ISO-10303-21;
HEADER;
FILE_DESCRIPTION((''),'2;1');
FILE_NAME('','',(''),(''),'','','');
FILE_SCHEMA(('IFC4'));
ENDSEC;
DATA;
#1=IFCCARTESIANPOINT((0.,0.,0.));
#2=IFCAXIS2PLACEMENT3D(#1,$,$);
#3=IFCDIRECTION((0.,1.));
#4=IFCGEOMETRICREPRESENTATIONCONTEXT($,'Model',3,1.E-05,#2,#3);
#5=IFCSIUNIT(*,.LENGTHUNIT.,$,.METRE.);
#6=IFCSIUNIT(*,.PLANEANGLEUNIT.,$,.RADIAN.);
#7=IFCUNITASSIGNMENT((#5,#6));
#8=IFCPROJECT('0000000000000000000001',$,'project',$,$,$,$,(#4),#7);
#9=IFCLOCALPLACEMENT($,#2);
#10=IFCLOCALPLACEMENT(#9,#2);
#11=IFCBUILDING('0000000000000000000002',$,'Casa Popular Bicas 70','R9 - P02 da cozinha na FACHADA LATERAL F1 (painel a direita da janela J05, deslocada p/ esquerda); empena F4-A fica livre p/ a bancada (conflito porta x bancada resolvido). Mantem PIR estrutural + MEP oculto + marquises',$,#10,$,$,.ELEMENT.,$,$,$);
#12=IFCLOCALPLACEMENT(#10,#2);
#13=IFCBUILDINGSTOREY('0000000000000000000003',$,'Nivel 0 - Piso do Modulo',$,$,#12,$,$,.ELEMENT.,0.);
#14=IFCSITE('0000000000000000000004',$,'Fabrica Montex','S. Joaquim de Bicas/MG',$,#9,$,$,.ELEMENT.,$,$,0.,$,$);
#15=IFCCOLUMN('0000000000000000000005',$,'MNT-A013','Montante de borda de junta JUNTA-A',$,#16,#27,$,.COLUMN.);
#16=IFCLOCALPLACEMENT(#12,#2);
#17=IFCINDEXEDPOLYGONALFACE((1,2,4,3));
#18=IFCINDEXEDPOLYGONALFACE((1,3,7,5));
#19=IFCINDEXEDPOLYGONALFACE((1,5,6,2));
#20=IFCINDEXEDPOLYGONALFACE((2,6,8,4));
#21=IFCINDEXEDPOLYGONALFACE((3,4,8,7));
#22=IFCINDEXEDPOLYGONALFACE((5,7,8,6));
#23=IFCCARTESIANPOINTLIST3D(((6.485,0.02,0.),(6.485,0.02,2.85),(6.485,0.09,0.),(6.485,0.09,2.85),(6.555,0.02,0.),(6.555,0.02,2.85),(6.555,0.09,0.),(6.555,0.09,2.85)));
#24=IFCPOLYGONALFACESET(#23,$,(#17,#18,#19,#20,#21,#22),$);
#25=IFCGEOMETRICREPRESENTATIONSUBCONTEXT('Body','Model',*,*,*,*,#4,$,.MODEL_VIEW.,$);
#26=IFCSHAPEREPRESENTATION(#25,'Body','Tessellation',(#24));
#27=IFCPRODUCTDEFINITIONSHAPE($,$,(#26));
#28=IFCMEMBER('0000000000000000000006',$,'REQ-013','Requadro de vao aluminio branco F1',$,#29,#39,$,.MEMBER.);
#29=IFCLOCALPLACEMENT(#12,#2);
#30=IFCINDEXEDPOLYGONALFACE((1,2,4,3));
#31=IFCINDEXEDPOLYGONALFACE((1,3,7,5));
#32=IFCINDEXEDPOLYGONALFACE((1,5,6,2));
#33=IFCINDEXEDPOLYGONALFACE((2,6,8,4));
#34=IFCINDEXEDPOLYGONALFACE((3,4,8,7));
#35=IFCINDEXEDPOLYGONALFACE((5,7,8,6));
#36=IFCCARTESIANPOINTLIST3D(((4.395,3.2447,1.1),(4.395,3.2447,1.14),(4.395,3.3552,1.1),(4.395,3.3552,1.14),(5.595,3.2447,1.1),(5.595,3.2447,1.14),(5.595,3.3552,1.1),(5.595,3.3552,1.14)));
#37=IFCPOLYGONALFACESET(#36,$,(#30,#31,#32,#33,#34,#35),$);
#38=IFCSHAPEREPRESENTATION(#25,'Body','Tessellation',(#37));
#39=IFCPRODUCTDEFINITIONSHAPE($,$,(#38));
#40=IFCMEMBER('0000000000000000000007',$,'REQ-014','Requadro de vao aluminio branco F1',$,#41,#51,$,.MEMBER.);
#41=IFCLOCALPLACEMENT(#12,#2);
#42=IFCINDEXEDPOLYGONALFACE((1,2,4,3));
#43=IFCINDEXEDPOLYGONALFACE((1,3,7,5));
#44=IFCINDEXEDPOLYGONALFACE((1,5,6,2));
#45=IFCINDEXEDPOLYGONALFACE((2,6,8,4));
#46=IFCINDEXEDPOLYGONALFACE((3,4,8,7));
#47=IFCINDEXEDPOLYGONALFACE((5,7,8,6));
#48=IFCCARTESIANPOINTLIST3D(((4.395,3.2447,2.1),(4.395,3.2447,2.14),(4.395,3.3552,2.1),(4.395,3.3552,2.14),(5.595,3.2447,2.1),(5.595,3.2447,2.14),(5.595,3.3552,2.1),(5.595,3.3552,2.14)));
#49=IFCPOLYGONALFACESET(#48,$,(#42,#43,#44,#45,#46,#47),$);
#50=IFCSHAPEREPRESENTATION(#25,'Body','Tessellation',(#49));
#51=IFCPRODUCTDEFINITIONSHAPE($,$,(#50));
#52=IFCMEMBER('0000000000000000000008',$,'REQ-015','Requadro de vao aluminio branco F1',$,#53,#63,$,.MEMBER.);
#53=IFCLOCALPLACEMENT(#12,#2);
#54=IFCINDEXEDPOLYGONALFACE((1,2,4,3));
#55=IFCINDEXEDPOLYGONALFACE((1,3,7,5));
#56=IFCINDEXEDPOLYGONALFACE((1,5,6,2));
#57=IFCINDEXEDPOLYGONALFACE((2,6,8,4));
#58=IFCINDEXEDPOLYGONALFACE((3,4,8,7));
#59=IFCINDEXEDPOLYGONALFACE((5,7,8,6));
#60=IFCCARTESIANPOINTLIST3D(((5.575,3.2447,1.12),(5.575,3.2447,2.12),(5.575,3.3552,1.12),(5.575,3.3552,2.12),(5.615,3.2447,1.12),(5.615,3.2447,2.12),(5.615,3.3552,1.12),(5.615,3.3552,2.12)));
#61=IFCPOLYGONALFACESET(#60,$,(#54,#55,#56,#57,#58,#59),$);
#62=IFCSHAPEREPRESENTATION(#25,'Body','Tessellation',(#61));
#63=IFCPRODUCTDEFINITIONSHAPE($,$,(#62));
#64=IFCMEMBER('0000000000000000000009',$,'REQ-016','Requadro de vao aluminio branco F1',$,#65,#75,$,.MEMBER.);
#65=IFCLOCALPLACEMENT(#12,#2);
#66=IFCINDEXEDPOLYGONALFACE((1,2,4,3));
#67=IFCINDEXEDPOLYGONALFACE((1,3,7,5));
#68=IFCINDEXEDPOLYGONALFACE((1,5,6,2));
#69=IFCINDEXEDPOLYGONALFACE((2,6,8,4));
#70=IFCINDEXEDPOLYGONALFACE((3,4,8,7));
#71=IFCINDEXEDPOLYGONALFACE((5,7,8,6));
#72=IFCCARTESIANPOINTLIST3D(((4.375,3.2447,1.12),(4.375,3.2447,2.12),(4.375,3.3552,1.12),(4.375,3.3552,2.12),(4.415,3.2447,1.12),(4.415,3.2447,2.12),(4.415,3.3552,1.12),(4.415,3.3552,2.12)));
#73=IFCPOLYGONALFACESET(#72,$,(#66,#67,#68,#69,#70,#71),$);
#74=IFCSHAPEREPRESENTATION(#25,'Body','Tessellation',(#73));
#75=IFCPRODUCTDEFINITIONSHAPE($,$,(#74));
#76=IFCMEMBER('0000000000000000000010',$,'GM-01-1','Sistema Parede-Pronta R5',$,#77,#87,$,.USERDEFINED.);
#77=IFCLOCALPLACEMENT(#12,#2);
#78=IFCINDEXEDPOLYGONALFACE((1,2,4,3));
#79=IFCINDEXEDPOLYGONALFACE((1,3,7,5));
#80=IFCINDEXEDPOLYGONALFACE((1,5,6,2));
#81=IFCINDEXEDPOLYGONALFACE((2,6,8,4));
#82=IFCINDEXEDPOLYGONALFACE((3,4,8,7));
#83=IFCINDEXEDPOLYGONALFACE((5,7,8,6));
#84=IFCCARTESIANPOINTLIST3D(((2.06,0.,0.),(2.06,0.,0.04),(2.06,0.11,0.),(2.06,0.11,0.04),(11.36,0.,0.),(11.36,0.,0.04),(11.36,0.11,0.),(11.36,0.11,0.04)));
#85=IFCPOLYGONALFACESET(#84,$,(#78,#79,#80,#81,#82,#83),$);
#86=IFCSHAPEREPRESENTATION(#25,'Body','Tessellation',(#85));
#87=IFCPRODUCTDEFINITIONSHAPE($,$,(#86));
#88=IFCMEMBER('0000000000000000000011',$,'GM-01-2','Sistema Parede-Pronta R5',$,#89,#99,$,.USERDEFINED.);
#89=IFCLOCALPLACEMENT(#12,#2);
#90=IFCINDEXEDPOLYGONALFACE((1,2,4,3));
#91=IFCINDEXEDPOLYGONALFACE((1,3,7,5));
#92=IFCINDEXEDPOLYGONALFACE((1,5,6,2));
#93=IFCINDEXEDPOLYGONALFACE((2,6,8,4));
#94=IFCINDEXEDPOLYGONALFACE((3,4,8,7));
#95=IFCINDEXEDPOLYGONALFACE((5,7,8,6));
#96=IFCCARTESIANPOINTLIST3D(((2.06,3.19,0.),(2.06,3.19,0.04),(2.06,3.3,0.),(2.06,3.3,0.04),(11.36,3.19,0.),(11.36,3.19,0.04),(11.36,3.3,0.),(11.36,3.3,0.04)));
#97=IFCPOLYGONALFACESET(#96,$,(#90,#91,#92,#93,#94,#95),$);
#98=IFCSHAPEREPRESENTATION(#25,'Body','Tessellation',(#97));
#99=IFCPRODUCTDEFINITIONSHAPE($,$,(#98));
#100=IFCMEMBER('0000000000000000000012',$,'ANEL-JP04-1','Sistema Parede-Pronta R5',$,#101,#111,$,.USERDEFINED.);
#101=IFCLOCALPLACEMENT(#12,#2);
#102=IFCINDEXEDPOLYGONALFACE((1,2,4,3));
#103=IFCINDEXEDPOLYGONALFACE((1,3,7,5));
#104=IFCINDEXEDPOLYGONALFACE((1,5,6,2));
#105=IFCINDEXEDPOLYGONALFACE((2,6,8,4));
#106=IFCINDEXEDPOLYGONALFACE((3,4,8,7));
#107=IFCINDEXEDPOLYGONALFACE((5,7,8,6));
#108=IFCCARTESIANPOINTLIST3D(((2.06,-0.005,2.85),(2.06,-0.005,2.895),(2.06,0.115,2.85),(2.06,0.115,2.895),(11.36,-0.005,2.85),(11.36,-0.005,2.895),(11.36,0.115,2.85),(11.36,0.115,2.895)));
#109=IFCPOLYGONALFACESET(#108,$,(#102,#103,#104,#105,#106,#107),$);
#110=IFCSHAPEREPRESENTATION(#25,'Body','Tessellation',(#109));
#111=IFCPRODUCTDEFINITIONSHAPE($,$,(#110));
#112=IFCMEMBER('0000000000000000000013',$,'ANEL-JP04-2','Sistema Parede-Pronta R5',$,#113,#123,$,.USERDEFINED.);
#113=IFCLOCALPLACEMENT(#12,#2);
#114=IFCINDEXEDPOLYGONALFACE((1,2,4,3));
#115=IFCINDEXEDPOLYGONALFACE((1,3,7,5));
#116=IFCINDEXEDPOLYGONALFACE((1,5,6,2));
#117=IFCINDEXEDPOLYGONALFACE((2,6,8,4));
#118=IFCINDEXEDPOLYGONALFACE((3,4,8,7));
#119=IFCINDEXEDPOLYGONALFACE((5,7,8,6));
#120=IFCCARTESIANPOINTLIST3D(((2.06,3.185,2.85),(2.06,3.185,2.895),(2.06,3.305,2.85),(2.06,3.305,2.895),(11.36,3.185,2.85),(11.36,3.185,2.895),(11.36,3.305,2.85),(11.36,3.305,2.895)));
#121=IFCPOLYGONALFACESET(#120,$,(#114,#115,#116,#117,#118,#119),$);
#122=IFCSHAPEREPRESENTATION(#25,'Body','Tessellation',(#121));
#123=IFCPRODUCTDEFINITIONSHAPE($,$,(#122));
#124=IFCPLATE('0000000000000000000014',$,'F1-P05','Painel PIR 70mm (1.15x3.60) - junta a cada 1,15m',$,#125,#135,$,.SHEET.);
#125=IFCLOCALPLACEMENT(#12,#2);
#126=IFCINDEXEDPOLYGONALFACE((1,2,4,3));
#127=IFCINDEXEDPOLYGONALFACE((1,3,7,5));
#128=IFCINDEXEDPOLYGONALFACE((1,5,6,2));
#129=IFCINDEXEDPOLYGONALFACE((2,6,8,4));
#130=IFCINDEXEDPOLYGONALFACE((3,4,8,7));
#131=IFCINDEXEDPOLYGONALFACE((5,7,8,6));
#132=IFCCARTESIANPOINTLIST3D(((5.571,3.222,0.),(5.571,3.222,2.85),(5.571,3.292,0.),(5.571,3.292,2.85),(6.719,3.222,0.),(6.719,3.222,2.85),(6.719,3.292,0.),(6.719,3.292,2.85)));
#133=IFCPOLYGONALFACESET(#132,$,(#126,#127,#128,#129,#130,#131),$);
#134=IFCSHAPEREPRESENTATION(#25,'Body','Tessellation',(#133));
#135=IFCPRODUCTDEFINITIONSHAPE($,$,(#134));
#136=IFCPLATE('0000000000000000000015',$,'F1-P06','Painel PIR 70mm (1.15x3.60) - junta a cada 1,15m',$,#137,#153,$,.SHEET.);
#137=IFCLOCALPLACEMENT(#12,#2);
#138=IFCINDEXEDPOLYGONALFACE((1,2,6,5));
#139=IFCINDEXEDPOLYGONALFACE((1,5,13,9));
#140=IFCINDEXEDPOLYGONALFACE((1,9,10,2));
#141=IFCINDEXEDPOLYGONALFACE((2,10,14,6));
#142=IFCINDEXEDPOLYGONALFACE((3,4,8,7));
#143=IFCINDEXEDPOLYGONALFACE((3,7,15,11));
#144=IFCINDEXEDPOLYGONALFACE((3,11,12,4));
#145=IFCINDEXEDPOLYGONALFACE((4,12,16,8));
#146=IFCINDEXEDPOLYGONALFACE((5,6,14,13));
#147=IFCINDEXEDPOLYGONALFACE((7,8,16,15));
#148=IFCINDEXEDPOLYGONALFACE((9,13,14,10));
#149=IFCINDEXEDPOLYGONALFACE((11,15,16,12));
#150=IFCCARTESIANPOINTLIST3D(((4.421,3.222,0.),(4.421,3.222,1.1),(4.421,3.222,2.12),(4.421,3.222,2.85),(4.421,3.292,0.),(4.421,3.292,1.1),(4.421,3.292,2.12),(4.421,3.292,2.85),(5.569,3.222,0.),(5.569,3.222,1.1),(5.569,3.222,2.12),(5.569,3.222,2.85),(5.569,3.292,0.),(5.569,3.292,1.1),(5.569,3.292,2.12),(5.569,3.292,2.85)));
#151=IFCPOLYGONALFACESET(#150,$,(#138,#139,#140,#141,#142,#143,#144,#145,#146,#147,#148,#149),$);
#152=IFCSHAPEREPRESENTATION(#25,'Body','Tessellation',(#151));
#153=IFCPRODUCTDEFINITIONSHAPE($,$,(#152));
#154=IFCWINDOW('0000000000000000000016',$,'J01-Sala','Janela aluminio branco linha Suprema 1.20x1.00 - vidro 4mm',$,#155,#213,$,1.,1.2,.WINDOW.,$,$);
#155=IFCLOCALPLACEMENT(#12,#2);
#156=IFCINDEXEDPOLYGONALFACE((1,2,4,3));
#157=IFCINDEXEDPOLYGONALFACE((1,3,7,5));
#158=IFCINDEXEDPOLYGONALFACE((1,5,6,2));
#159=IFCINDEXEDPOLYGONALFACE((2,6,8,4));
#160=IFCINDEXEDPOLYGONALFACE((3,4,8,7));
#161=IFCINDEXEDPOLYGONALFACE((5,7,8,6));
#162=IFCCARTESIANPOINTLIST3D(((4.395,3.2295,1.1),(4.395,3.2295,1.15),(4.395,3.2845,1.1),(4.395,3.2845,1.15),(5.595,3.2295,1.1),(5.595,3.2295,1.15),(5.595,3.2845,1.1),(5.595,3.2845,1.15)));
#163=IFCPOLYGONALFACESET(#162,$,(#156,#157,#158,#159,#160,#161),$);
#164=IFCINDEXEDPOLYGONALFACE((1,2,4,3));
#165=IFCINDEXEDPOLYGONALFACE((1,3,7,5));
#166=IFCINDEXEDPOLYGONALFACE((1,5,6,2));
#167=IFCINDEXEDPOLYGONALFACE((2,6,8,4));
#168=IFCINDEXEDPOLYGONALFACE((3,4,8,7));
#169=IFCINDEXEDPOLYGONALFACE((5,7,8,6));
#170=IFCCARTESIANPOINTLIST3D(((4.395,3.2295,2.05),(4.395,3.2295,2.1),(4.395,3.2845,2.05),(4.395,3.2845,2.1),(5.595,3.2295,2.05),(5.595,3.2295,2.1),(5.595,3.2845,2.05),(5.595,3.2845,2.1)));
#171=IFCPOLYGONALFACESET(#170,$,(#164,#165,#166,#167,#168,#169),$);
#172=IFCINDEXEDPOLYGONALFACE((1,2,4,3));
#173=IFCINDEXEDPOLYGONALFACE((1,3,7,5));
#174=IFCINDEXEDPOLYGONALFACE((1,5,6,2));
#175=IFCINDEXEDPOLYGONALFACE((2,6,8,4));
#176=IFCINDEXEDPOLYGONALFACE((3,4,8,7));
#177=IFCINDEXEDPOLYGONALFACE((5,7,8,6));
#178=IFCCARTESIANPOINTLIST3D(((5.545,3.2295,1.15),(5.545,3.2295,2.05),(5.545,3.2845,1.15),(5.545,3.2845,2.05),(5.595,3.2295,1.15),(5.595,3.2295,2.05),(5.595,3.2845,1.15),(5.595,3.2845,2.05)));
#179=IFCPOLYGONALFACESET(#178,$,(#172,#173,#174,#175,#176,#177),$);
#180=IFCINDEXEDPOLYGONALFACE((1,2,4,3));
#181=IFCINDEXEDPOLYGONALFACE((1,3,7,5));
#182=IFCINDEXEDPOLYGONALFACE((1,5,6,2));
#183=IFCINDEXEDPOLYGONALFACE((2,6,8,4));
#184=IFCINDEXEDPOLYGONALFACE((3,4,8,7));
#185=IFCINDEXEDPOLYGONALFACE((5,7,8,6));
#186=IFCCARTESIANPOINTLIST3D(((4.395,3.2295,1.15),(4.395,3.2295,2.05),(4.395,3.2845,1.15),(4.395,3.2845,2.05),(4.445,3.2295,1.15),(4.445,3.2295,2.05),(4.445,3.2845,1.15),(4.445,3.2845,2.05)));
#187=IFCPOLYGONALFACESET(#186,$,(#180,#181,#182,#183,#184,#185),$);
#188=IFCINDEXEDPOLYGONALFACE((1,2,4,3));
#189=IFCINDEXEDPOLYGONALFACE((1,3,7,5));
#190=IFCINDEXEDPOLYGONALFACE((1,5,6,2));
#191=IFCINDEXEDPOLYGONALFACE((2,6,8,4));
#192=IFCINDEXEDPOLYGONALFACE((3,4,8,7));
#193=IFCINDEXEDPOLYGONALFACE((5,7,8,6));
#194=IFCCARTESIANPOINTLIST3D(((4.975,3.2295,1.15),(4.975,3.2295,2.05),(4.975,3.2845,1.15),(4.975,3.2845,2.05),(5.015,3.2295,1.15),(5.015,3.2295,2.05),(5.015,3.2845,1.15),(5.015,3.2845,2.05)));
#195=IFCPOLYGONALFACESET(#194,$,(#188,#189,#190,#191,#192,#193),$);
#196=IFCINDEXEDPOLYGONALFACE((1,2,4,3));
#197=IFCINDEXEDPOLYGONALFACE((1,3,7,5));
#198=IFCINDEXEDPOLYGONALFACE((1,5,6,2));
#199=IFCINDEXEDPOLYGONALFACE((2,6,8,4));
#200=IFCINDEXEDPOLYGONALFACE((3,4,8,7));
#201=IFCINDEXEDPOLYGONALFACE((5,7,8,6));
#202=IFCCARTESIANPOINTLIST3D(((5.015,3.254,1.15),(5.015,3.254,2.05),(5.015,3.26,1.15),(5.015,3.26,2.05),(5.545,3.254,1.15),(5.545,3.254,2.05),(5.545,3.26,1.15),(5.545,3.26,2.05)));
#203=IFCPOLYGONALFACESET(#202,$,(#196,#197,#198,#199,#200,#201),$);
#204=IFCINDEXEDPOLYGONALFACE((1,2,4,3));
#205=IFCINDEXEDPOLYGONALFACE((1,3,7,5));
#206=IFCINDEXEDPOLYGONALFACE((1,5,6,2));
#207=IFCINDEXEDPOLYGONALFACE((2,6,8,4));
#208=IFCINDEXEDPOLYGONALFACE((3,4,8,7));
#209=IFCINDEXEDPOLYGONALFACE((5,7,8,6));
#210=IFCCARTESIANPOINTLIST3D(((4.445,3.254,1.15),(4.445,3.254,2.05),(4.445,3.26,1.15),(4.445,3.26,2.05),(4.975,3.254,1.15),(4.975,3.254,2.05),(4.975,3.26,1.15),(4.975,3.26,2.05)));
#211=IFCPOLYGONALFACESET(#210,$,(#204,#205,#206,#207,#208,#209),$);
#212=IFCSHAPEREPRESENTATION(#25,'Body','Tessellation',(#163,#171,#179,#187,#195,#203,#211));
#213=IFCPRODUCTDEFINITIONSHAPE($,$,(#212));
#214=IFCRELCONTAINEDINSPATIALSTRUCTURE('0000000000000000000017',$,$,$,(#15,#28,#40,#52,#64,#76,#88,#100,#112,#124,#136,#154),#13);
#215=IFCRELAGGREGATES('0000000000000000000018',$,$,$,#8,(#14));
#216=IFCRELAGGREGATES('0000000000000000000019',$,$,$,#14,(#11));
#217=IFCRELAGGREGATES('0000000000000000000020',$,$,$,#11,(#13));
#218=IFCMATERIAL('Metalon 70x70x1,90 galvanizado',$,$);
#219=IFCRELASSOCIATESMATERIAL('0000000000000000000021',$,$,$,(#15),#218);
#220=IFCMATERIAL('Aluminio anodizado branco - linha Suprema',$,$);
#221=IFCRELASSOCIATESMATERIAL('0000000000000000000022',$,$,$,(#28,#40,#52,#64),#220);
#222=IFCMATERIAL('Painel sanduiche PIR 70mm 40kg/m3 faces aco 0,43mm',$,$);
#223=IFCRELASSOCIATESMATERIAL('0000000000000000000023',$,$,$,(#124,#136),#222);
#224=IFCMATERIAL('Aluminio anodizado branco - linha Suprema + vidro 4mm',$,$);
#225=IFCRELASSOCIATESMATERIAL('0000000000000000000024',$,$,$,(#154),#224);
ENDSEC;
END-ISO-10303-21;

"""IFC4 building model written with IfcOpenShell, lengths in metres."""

from ifc_helpers import new_model, si_unit, direction, frame, frame_2d, origin, origin_2d, place, context, subcontext, project, spatial, rectangle, extrude, material, element, fill, save


model = new_model("IFC4")

# Units and contexts
model_context = context("Model", 3, precision=1e-05, world=origin(), true_north=direction((0.0, 1.0)))
body_context = subcontext(model_context, "Body", "Model", "MODEL_VIEW")
ifc_project = project(units=[si_unit("LENGTHUNIT", "METRE"), si_unit("PLANEANGLEUNIT", "RADIAN")], contexts=[model_context])

# Site, building, storey
site_placement = place(None, origin())
site = spatial("IfcSite", under=ifc_project, at=site_placement, Name="Fabrica Montex", Description="S. Joaquim de Bicas/MG", CompositionType="ELEMENT", RefElevation=0.0)
building_placement = place(site_placement, origin())
building = spatial("IfcBuilding", under=site, at=building_placement, Name="Casa Popular Bicas 70", Description="R9 - P02 da cozinha na FACHADA LATERAL F1 (painel a direita da janela J05, deslocada p/ esquerda); empena F4-A fica livre p/ a bancada (conflito porta x bancada resolvido). Mantem PIR estrutural + MEP oculto + marquises", CompositionType="ELEMENT")
storey_placement = place(building_placement, origin())
storey = spatial("IfcBuildingStorey", under=building, at=storey_placement, Name="Nivel 0 - Piso do Modulo", CompositionType="ELEMENT", Elevation=0.0)

# Column
ifc_material_1 = material(Name="Metalon 70x70x1,90 galvanizado")
column_placement = place(None, frame((6.52, 0.055, 0.0), z_axis=(0.0, 0.0, 1.0), x_axis=(-1.0, 0.0, 0.0)))
element("IfcColumn", 1, at=column_placement, inside=storey, material=ifc_material_1, Name="MNT-A013", Description="Montante de borda de junta JUNTA-A", PredefinedType="COLUMN", context=body_context, shape_type="SweptSolid", body=[
    extrude(rectangle(XDim=0.07, YDim=0.07, at=origin_2d()), origin(), (0.0, 0.0, 1.0), 2.85),
])

# Members
ifc_material_2 = material(Name="Aluminio anodizado branco - linha Suprema")
for number, where, z_axis, x_axis, name in (
    (2, (5.595, 3.3, 1.12), (-1.0, 0.0, 0.0), (0.0, 0.0, 1.0), "REQ-013"),
    (3, (5.595, 3.3, 2.12), (-1.0, 0.0, 0.0), (0.0, 0.0, 1.0), "REQ-014"),
):
    element("IfcMember", number, at=place(None, frame(where, z_axis=z_axis, x_axis=x_axis)), inside=storey, material=ifc_material_2, Name=name, Description="Requadro de vao aluminio branco F1", PredefinedType="MEMBER", context=body_context, shape_type="SweptSolid", body=[
        extrude(rectangle(XDim=0.04, YDim=0.1105, at=origin_2d()), origin(), (0.0, 0.0, 1.0), 1.2),
    ])
for number, where, z_axis, x_axis, name in (
    (4, (5.595, 3.3, 1.12), (0.0, 0.0, 1.0), (-1.0, 0.0, 0.0), "REQ-015"),
    (5, (4.395, 3.3, 1.12), (0.0, 0.0, 1.0), (-1.0, 0.0, 0.0), "REQ-016"),
):
    element("IfcMember", number, at=place(None, frame(where, z_axis=z_axis, x_axis=x_axis)), inside=storey, material=ifc_material_2, Name=name, Description="Requadro de vao aluminio branco F1", PredefinedType="MEMBER", context=body_context, shape_type="SweptSolid", body=[
        extrude(rectangle(XDim=0.04, YDim=0.1105, at=origin_2d()), origin(), (0.0, 0.0, 1.0), 1.0),
    ])
for number, where, name in (
    (6, (6.71, 0.055, 0.0), "GM-01-1"),
    (7, (6.71, 3.245, 0.0), "GM-01-2"),
):
    element("IfcMember", number, at=place(storey_placement, frame(where)), inside=storey, Name=name, Description="Sistema Parede-Pronta R5", PredefinedType="USERDEFINED", context=body_context, shape_type="SweptSolid", body=[
        extrude(rectangle(XDim=9.3, YDim=0.11, at=origin_2d()), origin(), (0.0, 0.0, 1.0), 0.04),
    ])
for number, where, name in (
    (8, (6.71, 0.055, 2.85), "ANEL-JP04-1"),
    (9, (6.71, 3.245, 2.85), "ANEL-JP04-2"),
):
    element("IfcMember", number, at=place(storey_placement, frame(where)), inside=storey, Name=name, Description="Sistema Parede-Pronta R5", PredefinedType="USERDEFINED", context=body_context, shape_type="SweptSolid", body=[
        extrude(rectangle(XDim=9.3, YDim=0.12, at=origin_2d()), origin(), (0.0, 0.0, 1.0), 0.045),
    ])

# Plate
ifc_material_3 = material(Name="Painel sanduiche PIR 70mm 40kg/m3 faces aco 0,43mm")
plate_1_placement = place(None, frame((6.719, 3.257, 0.0), z_axis=(0.0, 0.0, 1.0), x_axis=(-1.0, 0.0, 0.0)))
element("IfcPlate", 10, at=plate_1_placement, inside=storey, material=ifc_material_3, Name="F1-P05", Description="Painel PIR 70mm (1.15x3.60) - junta a cada 1,15m", PredefinedType="SHEET", context=body_context, shape_type="SweptSolid", body=[
    extrude(rectangle(XDim=1.148, YDim=0.07, at=frame_2d((0.574, 0.0))), origin(), (0.0, 0.0, 1.0), 2.85),
])

# Plate, opening, window
plate_2_placement = place(None, frame((5.569, 3.257, 0.0), z_axis=(0.0, 0.0, 1.0), x_axis=(-1.0, 0.0, 0.0)))
plate_2 = element("IfcPlate", 11, at=plate_2_placement, inside=storey, material=ifc_material_3, Name="F1-P06", Description="Painel PIR 70mm (1.15x3.60) - junta a cada 1,15m", PredefinedType="SHEET", context=body_context, shape_type="SweptSolid", body=[
    extrude(rectangle(XDim=1.148, YDim=0.07, at=frame_2d((0.574, 0.0))), origin(), (0.0, 0.0, 1.0), 2.85),
])
opening_1_placement = place(None, frame((5.595, 3.257, 1.1), z_axis=(0.0, 0.0, 1.0), x_axis=(-1.0, 0.0, 0.0)))
opening_1 = element("IfcOpeningElement", 12, at=opening_1_placement, cuts=plate_2, PredefinedType="OPENING", context=body_context, shape_type="SweptSolid", body=[
    extrude(rectangle(XDim=1.22, YDim=0.3, at=frame_2d((0.6, 0.0))), origin(), (0.0, 0.0, 1.0), 1.02),
])
ifc_material_4 = material(Name="Aluminio anodizado branco - linha Suprema + vidro 4mm")
window_placement = place(None, frame((5.595, 3.257, 1.1), z_axis=(0.0, 0.0, 1.0), x_axis=(-1.0, 0.0, 0.0)))
window = element("IfcWindow", 13, at=window_placement, inside=storey, material=ifc_material_4, Name="J01-Sala", Description="Janela aluminio branco linha Suprema 1.20x1.00 - vidro 4mm", OverallHeight=1.0, OverallWidth=1.2, PredefinedType="WINDOW", context=body_context, shape_type="SweptSolid", body=[
    extrude(rectangle(XDim=1.2, YDim=0.055, at=frame_2d((0.6, 0.0))), origin(), (0.0, 0.0, 1.0), 0.05),
    extrude(rectangle(XDim=1.2, YDim=0.055, at=frame_2d((0.6, 0.0))), frame((0.0, 0.0, 0.95)), (0.0, 0.0, 1.0), 0.05),
    extrude(rectangle(XDim=0.05, YDim=0.055, at=frame_2d((0.025, 0.0))), frame((0.0, 0.0, 0.05)), (0.0, 0.0, 1.0), 0.9),
    extrude(rectangle(XDim=0.05, YDim=0.055, at=frame_2d((1.175, 0.0))), frame((0.0, 0.0, 0.05)), (0.0, 0.0, 1.0), 0.9),
    extrude(rectangle(XDim=0.04, YDim=0.055, at=frame_2d((0.6, 0.0))), frame((0.0, 0.0, 0.05)), (0.0, 0.0, 1.0), 0.9),
    extrude(rectangle(XDim=0.53, YDim=0.006, at=frame_2d((0.315, 0.0))), frame((0.0, 0.0, 0.05)), (0.0, 0.0, 1.0), 0.9),
    extrude(rectangle(XDim=0.53, YDim=0.006, at=frame_2d((0.885, 0.0))), frame((0.0, 0.0, 0.05)), (0.0, 0.0, 1.0), 0.9),
])
fill(opening_1, window)

save(model, "model.ifc")
